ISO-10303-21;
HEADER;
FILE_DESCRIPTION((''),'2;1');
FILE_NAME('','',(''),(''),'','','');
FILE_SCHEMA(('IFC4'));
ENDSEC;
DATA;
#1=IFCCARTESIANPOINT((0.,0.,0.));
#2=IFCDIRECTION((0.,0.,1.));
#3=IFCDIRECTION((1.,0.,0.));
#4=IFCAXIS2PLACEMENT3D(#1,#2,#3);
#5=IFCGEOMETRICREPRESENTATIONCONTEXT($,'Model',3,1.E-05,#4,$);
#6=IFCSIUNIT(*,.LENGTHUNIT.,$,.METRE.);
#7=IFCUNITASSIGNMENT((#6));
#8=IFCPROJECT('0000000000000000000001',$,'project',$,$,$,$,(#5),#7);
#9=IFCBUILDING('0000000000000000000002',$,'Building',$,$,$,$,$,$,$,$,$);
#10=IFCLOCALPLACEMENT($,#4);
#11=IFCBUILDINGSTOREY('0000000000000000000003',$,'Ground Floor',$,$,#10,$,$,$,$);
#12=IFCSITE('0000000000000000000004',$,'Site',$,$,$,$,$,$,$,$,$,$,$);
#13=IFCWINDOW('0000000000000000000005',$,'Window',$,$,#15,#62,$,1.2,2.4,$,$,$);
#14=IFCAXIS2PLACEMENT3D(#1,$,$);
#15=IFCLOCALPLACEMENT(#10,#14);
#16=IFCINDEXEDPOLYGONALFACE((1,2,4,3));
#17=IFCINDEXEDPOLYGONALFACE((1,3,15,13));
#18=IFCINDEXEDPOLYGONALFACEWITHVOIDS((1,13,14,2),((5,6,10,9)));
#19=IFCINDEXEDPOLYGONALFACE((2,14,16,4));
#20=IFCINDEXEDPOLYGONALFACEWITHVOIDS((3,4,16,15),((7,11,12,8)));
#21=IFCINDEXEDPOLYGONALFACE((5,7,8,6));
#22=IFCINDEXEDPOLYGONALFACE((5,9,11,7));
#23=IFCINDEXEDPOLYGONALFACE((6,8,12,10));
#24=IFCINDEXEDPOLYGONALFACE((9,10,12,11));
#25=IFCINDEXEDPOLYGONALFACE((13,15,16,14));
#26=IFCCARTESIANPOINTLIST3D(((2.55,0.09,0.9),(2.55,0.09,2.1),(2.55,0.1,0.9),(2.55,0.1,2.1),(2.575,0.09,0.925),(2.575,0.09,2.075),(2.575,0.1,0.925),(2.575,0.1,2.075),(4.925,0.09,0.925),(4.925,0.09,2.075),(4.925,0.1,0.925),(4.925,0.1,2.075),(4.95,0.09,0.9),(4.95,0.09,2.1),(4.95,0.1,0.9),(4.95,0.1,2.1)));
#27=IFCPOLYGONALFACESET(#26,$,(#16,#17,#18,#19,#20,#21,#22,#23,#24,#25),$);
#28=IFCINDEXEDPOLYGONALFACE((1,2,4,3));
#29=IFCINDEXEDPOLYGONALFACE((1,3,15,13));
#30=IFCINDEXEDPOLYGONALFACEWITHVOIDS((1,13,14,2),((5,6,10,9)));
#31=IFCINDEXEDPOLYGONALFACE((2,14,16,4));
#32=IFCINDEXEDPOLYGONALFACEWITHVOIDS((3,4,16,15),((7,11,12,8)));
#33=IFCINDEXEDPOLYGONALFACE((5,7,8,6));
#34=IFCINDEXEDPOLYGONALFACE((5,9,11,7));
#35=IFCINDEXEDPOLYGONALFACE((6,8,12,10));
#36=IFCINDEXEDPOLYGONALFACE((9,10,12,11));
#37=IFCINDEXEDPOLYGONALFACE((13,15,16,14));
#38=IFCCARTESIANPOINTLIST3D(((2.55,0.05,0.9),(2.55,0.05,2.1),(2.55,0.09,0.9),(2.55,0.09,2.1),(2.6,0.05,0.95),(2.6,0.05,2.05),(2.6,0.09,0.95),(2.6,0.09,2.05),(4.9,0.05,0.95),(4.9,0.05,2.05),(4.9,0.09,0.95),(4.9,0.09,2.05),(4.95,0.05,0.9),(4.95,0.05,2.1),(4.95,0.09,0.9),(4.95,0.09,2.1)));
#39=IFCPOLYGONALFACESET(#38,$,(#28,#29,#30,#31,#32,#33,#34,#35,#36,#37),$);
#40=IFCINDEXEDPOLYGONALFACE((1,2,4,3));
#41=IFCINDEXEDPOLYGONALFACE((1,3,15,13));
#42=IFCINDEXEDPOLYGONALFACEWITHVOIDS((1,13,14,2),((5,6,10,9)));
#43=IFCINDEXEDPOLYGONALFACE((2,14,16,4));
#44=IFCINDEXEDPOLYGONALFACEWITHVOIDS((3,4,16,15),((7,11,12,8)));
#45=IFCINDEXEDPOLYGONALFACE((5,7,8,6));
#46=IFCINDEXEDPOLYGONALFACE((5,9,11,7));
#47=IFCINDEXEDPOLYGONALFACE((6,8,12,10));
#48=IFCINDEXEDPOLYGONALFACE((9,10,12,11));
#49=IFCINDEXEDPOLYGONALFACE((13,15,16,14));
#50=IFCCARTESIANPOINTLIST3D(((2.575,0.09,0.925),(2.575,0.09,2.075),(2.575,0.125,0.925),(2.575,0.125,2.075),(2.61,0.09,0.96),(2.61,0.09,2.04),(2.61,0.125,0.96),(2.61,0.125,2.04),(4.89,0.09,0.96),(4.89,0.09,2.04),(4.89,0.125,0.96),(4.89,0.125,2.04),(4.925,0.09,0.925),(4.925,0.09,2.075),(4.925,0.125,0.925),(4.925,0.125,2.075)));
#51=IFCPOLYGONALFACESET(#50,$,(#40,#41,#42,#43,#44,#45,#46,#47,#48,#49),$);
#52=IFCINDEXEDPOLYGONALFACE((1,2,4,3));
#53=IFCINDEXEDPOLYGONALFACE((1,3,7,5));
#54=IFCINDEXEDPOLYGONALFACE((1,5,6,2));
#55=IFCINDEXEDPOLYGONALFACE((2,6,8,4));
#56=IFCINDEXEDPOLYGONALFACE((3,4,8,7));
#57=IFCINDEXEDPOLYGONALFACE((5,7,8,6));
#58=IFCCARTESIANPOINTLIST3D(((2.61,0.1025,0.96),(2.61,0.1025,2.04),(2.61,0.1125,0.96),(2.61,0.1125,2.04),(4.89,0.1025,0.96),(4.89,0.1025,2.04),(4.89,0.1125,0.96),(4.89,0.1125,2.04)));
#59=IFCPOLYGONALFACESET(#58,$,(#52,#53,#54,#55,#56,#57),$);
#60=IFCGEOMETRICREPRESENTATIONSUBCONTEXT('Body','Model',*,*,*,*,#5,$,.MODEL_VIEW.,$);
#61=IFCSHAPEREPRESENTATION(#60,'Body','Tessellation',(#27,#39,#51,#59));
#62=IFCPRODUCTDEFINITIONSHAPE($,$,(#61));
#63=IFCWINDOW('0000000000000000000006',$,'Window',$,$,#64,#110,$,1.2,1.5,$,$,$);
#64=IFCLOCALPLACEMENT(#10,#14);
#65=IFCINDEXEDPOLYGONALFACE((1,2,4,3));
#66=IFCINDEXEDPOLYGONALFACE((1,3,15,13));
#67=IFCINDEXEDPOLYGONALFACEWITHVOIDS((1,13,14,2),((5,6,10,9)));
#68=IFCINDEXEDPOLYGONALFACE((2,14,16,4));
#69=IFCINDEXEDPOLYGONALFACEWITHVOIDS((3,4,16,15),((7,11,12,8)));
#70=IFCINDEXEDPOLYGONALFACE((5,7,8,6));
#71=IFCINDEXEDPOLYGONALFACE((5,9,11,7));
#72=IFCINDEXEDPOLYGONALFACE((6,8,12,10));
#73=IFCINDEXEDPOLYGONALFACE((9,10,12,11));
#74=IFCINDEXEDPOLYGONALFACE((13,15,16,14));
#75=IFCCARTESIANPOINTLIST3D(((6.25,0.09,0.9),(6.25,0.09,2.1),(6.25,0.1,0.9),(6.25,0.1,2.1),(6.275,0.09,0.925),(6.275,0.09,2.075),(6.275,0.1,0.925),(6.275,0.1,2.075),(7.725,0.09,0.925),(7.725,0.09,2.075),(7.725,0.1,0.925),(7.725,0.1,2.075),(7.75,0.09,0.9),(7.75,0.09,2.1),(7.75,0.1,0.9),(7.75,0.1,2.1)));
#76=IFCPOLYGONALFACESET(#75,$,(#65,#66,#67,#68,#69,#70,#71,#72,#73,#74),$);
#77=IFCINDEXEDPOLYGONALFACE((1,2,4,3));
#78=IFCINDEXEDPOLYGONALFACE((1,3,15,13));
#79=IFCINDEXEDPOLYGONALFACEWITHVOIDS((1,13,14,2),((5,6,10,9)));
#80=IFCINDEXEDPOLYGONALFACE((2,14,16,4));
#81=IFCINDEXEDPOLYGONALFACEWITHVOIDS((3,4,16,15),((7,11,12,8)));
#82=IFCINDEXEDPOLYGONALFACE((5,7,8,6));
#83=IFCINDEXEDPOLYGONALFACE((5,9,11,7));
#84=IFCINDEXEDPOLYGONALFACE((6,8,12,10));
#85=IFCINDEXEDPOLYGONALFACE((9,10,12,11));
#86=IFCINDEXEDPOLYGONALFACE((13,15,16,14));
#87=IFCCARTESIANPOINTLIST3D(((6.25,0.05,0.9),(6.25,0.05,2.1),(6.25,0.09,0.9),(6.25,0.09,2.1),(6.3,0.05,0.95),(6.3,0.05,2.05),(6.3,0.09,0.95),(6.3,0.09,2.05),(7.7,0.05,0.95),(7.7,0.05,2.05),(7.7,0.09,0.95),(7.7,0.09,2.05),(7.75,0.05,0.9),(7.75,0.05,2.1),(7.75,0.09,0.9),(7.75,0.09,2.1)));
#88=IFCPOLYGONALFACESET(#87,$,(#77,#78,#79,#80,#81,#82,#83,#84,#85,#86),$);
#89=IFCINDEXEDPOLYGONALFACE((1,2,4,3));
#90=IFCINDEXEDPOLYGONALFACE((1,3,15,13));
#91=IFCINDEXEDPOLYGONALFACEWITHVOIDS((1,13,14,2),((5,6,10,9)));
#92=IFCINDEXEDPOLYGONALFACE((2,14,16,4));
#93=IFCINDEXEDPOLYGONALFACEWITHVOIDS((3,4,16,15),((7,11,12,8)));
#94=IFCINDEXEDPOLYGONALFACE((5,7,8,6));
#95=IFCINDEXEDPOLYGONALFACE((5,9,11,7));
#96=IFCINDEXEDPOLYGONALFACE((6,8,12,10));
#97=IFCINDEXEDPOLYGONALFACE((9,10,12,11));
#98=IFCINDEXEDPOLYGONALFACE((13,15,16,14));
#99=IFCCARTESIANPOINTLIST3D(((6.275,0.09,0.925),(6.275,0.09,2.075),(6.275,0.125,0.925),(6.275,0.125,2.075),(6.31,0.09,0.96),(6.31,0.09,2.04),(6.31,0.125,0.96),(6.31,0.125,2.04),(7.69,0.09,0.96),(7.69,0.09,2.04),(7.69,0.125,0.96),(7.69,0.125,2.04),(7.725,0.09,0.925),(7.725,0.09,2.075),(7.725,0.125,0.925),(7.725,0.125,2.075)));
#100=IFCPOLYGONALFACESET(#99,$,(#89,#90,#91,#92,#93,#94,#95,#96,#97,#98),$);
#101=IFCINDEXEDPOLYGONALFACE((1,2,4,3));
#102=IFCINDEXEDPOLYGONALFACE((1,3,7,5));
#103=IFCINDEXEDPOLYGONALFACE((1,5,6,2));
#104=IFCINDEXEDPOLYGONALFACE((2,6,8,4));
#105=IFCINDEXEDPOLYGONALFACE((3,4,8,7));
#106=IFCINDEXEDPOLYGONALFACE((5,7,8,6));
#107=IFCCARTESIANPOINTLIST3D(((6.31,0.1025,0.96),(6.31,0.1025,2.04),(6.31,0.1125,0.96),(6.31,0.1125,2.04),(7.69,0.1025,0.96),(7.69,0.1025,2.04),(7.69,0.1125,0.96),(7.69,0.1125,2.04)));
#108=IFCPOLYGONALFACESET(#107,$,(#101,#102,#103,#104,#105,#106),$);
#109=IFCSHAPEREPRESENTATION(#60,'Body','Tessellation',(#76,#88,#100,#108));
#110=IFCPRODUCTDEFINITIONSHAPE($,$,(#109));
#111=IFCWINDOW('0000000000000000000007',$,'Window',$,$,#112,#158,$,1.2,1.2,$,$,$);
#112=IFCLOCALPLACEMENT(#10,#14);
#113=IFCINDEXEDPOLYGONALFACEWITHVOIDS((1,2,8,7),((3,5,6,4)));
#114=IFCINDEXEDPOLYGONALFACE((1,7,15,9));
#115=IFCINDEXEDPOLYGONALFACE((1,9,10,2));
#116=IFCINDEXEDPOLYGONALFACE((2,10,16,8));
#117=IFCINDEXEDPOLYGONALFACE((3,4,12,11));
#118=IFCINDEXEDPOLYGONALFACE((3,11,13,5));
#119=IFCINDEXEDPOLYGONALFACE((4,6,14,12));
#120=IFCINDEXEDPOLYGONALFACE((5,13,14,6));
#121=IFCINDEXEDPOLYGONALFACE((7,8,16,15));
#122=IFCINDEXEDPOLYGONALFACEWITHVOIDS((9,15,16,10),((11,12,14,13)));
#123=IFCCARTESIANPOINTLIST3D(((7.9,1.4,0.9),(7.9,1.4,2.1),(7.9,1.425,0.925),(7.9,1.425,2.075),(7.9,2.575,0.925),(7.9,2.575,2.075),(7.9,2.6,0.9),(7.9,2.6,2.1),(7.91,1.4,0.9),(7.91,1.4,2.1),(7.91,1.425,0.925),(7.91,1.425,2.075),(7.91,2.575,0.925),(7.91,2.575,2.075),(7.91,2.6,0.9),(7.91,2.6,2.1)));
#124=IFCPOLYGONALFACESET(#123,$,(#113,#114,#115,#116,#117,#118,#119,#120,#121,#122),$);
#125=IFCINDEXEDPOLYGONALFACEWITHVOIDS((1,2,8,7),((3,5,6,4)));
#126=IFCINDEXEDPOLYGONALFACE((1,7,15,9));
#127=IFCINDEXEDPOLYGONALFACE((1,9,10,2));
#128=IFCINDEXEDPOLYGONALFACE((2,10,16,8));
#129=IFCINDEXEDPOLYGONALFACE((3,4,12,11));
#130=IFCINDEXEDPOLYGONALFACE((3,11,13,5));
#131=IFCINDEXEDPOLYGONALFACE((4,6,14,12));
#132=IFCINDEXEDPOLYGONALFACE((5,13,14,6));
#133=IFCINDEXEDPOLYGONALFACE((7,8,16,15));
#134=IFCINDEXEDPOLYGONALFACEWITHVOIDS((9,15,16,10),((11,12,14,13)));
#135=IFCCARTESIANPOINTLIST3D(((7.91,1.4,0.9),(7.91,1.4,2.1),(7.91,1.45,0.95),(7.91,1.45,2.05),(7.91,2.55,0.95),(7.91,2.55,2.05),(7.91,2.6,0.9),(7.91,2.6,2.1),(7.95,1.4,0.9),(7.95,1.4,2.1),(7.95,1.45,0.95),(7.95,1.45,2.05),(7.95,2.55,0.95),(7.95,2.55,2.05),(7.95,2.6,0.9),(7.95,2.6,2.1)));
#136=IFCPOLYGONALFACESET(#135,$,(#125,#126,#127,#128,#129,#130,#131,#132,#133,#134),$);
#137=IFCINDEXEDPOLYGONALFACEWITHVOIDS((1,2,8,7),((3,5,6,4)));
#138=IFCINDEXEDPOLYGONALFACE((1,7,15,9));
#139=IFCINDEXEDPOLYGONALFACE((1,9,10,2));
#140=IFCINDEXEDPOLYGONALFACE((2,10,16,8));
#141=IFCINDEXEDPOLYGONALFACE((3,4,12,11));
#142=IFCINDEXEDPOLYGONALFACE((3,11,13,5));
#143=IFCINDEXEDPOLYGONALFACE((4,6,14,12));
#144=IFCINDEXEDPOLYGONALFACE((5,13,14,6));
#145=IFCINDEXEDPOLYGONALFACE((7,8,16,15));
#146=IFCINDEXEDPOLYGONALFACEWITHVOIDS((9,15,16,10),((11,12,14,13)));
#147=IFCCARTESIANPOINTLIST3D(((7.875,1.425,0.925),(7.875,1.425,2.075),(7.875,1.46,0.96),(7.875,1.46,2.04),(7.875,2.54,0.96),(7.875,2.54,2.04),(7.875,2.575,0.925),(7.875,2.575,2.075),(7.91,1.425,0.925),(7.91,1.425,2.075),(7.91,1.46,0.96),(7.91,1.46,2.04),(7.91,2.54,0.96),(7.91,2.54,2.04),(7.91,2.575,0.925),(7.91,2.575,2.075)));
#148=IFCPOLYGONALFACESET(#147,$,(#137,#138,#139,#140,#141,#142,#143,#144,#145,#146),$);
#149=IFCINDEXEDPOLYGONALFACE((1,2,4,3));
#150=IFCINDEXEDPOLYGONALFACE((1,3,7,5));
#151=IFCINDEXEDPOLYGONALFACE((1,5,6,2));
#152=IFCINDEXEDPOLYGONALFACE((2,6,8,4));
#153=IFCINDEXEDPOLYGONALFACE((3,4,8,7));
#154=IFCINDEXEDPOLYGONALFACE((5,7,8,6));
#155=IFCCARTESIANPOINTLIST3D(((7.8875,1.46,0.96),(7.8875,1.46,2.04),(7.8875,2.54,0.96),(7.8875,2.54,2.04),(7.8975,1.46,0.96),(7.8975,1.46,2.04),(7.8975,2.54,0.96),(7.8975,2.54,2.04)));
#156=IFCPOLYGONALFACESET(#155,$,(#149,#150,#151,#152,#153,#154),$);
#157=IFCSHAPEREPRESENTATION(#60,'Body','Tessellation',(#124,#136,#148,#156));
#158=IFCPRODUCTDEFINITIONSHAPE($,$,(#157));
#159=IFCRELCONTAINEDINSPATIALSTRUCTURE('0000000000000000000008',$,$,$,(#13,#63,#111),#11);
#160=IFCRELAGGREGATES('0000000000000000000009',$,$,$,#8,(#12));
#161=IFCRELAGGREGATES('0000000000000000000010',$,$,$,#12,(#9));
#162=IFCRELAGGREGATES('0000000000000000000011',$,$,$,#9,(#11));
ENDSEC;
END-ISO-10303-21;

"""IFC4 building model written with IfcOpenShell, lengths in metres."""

from ifc_helpers import new_model, si_unit, frame, origin_with_axes, place, context, subcontext, project, spatial, line, indexed_curve, outline, extrude, element, save


model = new_model("IFC4")

# Units and contexts
model_context = context("Model", 3, precision=1e-05, world=origin_with_axes())
body_context = subcontext(model_context, "Body", "Model", "MODEL_VIEW")
ifc_project = project(units=[si_unit("LENGTHUNIT", "METRE")], contexts=[model_context])

# Site, building, storey
site = spatial("IfcSite", under=ifc_project, Name="Site")
building = spatial("IfcBuilding", under=site, Name="Building")
storey_placement = place(None, origin_with_axes())
storey = spatial("IfcBuildingStorey", under=building, at=storey_placement, Name="Ground Floor")

# Windows
window_1_placement = place(storey_placement, frame((2.55, 0.0, 0.9), z_axis=(0.0, 0.0, 1.0), x_axis=(1.0, 0.0, 0.0)))
element("IfcWindow", 1, at=window_1_placement, inside=storey, Name="Window", OverallHeight=1.2, OverallWidth=2.4, context=body_context, shape_type="SweptSolid", body=[
    extrude(outline(indexed_curve([(0.0, 0.0), (2.4, 0.0), (2.4, 1.2), (0.0, 1.2)], segments=[line(1, 2, 3, 4, 1)]), holes=[indexed_curve([(0.025, 0.025), (2.375, 0.025), (2.375, 1.175), (0.025, 1.175)], segments=[line(1, 2, 3, 4, 1)])]), frame((0.0, 0.09, 0.0), z_axis=(0.0, -1.0, 0.0), x_axis=(1.0, 0.0, 0.0)), (0.0, 0.0, -1.0), 0.01),
    extrude(outline(indexed_curve([(0.0, 0.0), (2.4, 0.0), (2.4, 1.2), (0.0, 1.2)], segments=[line(1, 2, 3, 4, 1)]), holes=[indexed_curve([(0.05, 0.05), (2.35, 0.05), (2.35, 1.15), (0.05, 1.15)], segments=[line(1, 2, 3, 4, 1)])]), frame((0.0, 0.05, 0.0), z_axis=(0.0, -1.0, 0.0), x_axis=(1.0, 0.0, 0.0)), (0.0, 0.0, -1.0), 0.04),
    extrude(outline(indexed_curve([(0.0, 0.0), (2.35, 0.0), (2.35, 1.15), (0.0, 1.15)], segments=[line(1, 2, 3, 4, 1)]), holes=[indexed_curve([(0.035, 0.035), (2.315, 0.035), (2.315, 1.115), (0.035, 1.115)], segments=[line(1, 2, 3, 4, 1)])]), frame((0.025, 0.09, 0.025), z_axis=(0.0, -1.0, 0.0), x_axis=(1.0, 0.0, 0.0)), (0.0, 0.0, -1.0), 0.035),
    extrude(outline(indexed_curve([(0.035, 0.035), (2.315, 0.035), (2.315, 1.115), (0.035, 1.115)], segments=[line(1, 2, 3, 4, 1)])), frame((0.025, 0.1025, 0.025), z_axis=(0.0, -1.0, 0.0), x_axis=(1.0, 0.0, 0.0)), (0.0, 0.0, -1.0), 0.01),
])
window_2_placement = place(storey_placement, frame((6.25, 0.0, 0.9), z_axis=(0.0, 0.0, 1.0), x_axis=(1.0, 0.0, 0.0)))
element("IfcWindow", 2, at=window_2_placement, inside=storey, Name="Window", OverallHeight=1.2, OverallWidth=1.5, context=body_context, shape_type="SweptSolid", body=[
    extrude(outline(indexed_curve([(0.0, 0.0), (1.5, 0.0), (1.5, 1.2), (0.0, 1.2)], segments=[line(1, 2, 3, 4, 1)]), holes=[indexed_curve([(0.025, 0.025), (1.475, 0.025), (1.475, 1.175), (0.025, 1.175)], segments=[line(1, 2, 3, 4, 1)])]), frame((0.0, 0.09, 0.0), z_axis=(0.0, -1.0, 0.0), x_axis=(1.0, 0.0, 0.0)), (0.0, 0.0, -1.0), 0.01),
    extrude(outline(indexed_curve([(0.0, 0.0), (1.5, 0.0), (1.5, 1.2), (0.0, 1.2)], segments=[line(1, 2, 3, 4, 1)]), holes=[indexed_curve([(0.05, 0.05), (1.45, 0.05), (1.45, 1.15), (0.05, 1.15)], segments=[line(1, 2, 3, 4, 1)])]), frame((0.0, 0.05, 0.0), z_axis=(0.0, -1.0, 0.0), x_axis=(1.0, 0.0, 0.0)), (0.0, 0.0, -1.0), 0.04),
    extrude(outline(indexed_curve([(0.0, 0.0), (1.45, 0.0), (1.45, 1.15), (0.0, 1.15)], segments=[line(1, 2, 3, 4, 1)]), holes=[indexed_curve([(0.035, 0.035), (1.415, 0.035), (1.415, 1.115), (0.035, 1.115)], segments=[line(1, 2, 3, 4, 1)])]), frame((0.025, 0.09, 0.025), z_axis=(0.0, -1.0, 0.0), x_axis=(1.0, 0.0, 0.0)), (0.0, 0.0, -1.0), 0.035),
    extrude(outline(indexed_curve([(0.035, 0.035), (1.415, 0.035), (1.415, 1.115), (0.035, 1.115)], segments=[line(1, 2, 3, 4, 1)])), frame((0.025, 0.1025, 0.025), z_axis=(0.0, -1.0, 0.0), x_axis=(1.0, 0.0, 0.0)), (0.0, 0.0, -1.0), 0.01),
])
window_3_placement = place(storey_placement, frame((8.0, 1.4, 0.9), z_axis=(0.0, 0.0, 1.0), x_axis=(0.0, 1.0, 0.0)))
element("IfcWindow", 3, at=window_3_placement, inside=storey, Name="Window", OverallHeight=1.2, OverallWidth=1.2, context=body_context, shape_type="SweptSolid", body=[
    extrude(outline(indexed_curve([(0.0, 0.0), (1.2, 0.0), (1.2, 1.2), (0.0, 1.2)], segments=[line(1, 2, 3, 4, 1)]), holes=[indexed_curve([(0.025, 0.025), (1.175, 0.025), (1.175, 1.175), (0.025, 1.175)], segments=[line(1, 2, 3, 4, 1)])]), frame((0.0, 0.09, 0.0), z_axis=(0.0, -1.0, 0.0), x_axis=(1.0, 0.0, 0.0)), (0.0, 0.0, -1.0), 0.01),
    extrude(outline(indexed_curve([(0.0, 0.0), (1.2, 0.0), (1.2, 1.2), (0.0, 1.2)], segments=[line(1, 2, 3, 4, 1)]), holes=[indexed_curve([(0.05, 0.05), (1.15, 0.05), (1.15, 1.15), (0.05, 1.15)], segments=[line(1, 2, 3, 4, 1)])]), frame((0.0, 0.05, 0.0), z_axis=(0.0, -1.0, 0.0), x_axis=(1.0, 0.0, 0.0)), (0.0, 0.0, -1.0), 0.04),
    extrude(outline(indexed_curve([(0.0, 0.0), (1.15, 0.0), (1.15, 1.15), (0.0, 1.15)], segments=[line(1, 2, 3, 4, 1)]), holes=[indexed_curve([(0.035, 0.035), (1.115, 0.035), (1.115, 1.115), (0.035, 1.115)], segments=[line(1, 2, 3, 4, 1)])]), frame((0.025, 0.09, 0.025), z_axis=(0.0, -1.0, 0.0), x_axis=(1.0, 0.0, 0.0)), (0.0, 0.0, -1.0), 0.035),
    extrude(outline(indexed_curve([(0.035, 0.035), (1.115, 0.035), (1.115, 1.115), (0.035, 1.115)], segments=[line(1, 2, 3, 4, 1)])), frame((0.025, 0.1025, 0.025), z_axis=(0.0, -1.0, 0.0), x_axis=(1.0, 0.0, 0.0)), (0.0, 0.0, -1.0), 0.01),
])

save(model, "model.ifc")
